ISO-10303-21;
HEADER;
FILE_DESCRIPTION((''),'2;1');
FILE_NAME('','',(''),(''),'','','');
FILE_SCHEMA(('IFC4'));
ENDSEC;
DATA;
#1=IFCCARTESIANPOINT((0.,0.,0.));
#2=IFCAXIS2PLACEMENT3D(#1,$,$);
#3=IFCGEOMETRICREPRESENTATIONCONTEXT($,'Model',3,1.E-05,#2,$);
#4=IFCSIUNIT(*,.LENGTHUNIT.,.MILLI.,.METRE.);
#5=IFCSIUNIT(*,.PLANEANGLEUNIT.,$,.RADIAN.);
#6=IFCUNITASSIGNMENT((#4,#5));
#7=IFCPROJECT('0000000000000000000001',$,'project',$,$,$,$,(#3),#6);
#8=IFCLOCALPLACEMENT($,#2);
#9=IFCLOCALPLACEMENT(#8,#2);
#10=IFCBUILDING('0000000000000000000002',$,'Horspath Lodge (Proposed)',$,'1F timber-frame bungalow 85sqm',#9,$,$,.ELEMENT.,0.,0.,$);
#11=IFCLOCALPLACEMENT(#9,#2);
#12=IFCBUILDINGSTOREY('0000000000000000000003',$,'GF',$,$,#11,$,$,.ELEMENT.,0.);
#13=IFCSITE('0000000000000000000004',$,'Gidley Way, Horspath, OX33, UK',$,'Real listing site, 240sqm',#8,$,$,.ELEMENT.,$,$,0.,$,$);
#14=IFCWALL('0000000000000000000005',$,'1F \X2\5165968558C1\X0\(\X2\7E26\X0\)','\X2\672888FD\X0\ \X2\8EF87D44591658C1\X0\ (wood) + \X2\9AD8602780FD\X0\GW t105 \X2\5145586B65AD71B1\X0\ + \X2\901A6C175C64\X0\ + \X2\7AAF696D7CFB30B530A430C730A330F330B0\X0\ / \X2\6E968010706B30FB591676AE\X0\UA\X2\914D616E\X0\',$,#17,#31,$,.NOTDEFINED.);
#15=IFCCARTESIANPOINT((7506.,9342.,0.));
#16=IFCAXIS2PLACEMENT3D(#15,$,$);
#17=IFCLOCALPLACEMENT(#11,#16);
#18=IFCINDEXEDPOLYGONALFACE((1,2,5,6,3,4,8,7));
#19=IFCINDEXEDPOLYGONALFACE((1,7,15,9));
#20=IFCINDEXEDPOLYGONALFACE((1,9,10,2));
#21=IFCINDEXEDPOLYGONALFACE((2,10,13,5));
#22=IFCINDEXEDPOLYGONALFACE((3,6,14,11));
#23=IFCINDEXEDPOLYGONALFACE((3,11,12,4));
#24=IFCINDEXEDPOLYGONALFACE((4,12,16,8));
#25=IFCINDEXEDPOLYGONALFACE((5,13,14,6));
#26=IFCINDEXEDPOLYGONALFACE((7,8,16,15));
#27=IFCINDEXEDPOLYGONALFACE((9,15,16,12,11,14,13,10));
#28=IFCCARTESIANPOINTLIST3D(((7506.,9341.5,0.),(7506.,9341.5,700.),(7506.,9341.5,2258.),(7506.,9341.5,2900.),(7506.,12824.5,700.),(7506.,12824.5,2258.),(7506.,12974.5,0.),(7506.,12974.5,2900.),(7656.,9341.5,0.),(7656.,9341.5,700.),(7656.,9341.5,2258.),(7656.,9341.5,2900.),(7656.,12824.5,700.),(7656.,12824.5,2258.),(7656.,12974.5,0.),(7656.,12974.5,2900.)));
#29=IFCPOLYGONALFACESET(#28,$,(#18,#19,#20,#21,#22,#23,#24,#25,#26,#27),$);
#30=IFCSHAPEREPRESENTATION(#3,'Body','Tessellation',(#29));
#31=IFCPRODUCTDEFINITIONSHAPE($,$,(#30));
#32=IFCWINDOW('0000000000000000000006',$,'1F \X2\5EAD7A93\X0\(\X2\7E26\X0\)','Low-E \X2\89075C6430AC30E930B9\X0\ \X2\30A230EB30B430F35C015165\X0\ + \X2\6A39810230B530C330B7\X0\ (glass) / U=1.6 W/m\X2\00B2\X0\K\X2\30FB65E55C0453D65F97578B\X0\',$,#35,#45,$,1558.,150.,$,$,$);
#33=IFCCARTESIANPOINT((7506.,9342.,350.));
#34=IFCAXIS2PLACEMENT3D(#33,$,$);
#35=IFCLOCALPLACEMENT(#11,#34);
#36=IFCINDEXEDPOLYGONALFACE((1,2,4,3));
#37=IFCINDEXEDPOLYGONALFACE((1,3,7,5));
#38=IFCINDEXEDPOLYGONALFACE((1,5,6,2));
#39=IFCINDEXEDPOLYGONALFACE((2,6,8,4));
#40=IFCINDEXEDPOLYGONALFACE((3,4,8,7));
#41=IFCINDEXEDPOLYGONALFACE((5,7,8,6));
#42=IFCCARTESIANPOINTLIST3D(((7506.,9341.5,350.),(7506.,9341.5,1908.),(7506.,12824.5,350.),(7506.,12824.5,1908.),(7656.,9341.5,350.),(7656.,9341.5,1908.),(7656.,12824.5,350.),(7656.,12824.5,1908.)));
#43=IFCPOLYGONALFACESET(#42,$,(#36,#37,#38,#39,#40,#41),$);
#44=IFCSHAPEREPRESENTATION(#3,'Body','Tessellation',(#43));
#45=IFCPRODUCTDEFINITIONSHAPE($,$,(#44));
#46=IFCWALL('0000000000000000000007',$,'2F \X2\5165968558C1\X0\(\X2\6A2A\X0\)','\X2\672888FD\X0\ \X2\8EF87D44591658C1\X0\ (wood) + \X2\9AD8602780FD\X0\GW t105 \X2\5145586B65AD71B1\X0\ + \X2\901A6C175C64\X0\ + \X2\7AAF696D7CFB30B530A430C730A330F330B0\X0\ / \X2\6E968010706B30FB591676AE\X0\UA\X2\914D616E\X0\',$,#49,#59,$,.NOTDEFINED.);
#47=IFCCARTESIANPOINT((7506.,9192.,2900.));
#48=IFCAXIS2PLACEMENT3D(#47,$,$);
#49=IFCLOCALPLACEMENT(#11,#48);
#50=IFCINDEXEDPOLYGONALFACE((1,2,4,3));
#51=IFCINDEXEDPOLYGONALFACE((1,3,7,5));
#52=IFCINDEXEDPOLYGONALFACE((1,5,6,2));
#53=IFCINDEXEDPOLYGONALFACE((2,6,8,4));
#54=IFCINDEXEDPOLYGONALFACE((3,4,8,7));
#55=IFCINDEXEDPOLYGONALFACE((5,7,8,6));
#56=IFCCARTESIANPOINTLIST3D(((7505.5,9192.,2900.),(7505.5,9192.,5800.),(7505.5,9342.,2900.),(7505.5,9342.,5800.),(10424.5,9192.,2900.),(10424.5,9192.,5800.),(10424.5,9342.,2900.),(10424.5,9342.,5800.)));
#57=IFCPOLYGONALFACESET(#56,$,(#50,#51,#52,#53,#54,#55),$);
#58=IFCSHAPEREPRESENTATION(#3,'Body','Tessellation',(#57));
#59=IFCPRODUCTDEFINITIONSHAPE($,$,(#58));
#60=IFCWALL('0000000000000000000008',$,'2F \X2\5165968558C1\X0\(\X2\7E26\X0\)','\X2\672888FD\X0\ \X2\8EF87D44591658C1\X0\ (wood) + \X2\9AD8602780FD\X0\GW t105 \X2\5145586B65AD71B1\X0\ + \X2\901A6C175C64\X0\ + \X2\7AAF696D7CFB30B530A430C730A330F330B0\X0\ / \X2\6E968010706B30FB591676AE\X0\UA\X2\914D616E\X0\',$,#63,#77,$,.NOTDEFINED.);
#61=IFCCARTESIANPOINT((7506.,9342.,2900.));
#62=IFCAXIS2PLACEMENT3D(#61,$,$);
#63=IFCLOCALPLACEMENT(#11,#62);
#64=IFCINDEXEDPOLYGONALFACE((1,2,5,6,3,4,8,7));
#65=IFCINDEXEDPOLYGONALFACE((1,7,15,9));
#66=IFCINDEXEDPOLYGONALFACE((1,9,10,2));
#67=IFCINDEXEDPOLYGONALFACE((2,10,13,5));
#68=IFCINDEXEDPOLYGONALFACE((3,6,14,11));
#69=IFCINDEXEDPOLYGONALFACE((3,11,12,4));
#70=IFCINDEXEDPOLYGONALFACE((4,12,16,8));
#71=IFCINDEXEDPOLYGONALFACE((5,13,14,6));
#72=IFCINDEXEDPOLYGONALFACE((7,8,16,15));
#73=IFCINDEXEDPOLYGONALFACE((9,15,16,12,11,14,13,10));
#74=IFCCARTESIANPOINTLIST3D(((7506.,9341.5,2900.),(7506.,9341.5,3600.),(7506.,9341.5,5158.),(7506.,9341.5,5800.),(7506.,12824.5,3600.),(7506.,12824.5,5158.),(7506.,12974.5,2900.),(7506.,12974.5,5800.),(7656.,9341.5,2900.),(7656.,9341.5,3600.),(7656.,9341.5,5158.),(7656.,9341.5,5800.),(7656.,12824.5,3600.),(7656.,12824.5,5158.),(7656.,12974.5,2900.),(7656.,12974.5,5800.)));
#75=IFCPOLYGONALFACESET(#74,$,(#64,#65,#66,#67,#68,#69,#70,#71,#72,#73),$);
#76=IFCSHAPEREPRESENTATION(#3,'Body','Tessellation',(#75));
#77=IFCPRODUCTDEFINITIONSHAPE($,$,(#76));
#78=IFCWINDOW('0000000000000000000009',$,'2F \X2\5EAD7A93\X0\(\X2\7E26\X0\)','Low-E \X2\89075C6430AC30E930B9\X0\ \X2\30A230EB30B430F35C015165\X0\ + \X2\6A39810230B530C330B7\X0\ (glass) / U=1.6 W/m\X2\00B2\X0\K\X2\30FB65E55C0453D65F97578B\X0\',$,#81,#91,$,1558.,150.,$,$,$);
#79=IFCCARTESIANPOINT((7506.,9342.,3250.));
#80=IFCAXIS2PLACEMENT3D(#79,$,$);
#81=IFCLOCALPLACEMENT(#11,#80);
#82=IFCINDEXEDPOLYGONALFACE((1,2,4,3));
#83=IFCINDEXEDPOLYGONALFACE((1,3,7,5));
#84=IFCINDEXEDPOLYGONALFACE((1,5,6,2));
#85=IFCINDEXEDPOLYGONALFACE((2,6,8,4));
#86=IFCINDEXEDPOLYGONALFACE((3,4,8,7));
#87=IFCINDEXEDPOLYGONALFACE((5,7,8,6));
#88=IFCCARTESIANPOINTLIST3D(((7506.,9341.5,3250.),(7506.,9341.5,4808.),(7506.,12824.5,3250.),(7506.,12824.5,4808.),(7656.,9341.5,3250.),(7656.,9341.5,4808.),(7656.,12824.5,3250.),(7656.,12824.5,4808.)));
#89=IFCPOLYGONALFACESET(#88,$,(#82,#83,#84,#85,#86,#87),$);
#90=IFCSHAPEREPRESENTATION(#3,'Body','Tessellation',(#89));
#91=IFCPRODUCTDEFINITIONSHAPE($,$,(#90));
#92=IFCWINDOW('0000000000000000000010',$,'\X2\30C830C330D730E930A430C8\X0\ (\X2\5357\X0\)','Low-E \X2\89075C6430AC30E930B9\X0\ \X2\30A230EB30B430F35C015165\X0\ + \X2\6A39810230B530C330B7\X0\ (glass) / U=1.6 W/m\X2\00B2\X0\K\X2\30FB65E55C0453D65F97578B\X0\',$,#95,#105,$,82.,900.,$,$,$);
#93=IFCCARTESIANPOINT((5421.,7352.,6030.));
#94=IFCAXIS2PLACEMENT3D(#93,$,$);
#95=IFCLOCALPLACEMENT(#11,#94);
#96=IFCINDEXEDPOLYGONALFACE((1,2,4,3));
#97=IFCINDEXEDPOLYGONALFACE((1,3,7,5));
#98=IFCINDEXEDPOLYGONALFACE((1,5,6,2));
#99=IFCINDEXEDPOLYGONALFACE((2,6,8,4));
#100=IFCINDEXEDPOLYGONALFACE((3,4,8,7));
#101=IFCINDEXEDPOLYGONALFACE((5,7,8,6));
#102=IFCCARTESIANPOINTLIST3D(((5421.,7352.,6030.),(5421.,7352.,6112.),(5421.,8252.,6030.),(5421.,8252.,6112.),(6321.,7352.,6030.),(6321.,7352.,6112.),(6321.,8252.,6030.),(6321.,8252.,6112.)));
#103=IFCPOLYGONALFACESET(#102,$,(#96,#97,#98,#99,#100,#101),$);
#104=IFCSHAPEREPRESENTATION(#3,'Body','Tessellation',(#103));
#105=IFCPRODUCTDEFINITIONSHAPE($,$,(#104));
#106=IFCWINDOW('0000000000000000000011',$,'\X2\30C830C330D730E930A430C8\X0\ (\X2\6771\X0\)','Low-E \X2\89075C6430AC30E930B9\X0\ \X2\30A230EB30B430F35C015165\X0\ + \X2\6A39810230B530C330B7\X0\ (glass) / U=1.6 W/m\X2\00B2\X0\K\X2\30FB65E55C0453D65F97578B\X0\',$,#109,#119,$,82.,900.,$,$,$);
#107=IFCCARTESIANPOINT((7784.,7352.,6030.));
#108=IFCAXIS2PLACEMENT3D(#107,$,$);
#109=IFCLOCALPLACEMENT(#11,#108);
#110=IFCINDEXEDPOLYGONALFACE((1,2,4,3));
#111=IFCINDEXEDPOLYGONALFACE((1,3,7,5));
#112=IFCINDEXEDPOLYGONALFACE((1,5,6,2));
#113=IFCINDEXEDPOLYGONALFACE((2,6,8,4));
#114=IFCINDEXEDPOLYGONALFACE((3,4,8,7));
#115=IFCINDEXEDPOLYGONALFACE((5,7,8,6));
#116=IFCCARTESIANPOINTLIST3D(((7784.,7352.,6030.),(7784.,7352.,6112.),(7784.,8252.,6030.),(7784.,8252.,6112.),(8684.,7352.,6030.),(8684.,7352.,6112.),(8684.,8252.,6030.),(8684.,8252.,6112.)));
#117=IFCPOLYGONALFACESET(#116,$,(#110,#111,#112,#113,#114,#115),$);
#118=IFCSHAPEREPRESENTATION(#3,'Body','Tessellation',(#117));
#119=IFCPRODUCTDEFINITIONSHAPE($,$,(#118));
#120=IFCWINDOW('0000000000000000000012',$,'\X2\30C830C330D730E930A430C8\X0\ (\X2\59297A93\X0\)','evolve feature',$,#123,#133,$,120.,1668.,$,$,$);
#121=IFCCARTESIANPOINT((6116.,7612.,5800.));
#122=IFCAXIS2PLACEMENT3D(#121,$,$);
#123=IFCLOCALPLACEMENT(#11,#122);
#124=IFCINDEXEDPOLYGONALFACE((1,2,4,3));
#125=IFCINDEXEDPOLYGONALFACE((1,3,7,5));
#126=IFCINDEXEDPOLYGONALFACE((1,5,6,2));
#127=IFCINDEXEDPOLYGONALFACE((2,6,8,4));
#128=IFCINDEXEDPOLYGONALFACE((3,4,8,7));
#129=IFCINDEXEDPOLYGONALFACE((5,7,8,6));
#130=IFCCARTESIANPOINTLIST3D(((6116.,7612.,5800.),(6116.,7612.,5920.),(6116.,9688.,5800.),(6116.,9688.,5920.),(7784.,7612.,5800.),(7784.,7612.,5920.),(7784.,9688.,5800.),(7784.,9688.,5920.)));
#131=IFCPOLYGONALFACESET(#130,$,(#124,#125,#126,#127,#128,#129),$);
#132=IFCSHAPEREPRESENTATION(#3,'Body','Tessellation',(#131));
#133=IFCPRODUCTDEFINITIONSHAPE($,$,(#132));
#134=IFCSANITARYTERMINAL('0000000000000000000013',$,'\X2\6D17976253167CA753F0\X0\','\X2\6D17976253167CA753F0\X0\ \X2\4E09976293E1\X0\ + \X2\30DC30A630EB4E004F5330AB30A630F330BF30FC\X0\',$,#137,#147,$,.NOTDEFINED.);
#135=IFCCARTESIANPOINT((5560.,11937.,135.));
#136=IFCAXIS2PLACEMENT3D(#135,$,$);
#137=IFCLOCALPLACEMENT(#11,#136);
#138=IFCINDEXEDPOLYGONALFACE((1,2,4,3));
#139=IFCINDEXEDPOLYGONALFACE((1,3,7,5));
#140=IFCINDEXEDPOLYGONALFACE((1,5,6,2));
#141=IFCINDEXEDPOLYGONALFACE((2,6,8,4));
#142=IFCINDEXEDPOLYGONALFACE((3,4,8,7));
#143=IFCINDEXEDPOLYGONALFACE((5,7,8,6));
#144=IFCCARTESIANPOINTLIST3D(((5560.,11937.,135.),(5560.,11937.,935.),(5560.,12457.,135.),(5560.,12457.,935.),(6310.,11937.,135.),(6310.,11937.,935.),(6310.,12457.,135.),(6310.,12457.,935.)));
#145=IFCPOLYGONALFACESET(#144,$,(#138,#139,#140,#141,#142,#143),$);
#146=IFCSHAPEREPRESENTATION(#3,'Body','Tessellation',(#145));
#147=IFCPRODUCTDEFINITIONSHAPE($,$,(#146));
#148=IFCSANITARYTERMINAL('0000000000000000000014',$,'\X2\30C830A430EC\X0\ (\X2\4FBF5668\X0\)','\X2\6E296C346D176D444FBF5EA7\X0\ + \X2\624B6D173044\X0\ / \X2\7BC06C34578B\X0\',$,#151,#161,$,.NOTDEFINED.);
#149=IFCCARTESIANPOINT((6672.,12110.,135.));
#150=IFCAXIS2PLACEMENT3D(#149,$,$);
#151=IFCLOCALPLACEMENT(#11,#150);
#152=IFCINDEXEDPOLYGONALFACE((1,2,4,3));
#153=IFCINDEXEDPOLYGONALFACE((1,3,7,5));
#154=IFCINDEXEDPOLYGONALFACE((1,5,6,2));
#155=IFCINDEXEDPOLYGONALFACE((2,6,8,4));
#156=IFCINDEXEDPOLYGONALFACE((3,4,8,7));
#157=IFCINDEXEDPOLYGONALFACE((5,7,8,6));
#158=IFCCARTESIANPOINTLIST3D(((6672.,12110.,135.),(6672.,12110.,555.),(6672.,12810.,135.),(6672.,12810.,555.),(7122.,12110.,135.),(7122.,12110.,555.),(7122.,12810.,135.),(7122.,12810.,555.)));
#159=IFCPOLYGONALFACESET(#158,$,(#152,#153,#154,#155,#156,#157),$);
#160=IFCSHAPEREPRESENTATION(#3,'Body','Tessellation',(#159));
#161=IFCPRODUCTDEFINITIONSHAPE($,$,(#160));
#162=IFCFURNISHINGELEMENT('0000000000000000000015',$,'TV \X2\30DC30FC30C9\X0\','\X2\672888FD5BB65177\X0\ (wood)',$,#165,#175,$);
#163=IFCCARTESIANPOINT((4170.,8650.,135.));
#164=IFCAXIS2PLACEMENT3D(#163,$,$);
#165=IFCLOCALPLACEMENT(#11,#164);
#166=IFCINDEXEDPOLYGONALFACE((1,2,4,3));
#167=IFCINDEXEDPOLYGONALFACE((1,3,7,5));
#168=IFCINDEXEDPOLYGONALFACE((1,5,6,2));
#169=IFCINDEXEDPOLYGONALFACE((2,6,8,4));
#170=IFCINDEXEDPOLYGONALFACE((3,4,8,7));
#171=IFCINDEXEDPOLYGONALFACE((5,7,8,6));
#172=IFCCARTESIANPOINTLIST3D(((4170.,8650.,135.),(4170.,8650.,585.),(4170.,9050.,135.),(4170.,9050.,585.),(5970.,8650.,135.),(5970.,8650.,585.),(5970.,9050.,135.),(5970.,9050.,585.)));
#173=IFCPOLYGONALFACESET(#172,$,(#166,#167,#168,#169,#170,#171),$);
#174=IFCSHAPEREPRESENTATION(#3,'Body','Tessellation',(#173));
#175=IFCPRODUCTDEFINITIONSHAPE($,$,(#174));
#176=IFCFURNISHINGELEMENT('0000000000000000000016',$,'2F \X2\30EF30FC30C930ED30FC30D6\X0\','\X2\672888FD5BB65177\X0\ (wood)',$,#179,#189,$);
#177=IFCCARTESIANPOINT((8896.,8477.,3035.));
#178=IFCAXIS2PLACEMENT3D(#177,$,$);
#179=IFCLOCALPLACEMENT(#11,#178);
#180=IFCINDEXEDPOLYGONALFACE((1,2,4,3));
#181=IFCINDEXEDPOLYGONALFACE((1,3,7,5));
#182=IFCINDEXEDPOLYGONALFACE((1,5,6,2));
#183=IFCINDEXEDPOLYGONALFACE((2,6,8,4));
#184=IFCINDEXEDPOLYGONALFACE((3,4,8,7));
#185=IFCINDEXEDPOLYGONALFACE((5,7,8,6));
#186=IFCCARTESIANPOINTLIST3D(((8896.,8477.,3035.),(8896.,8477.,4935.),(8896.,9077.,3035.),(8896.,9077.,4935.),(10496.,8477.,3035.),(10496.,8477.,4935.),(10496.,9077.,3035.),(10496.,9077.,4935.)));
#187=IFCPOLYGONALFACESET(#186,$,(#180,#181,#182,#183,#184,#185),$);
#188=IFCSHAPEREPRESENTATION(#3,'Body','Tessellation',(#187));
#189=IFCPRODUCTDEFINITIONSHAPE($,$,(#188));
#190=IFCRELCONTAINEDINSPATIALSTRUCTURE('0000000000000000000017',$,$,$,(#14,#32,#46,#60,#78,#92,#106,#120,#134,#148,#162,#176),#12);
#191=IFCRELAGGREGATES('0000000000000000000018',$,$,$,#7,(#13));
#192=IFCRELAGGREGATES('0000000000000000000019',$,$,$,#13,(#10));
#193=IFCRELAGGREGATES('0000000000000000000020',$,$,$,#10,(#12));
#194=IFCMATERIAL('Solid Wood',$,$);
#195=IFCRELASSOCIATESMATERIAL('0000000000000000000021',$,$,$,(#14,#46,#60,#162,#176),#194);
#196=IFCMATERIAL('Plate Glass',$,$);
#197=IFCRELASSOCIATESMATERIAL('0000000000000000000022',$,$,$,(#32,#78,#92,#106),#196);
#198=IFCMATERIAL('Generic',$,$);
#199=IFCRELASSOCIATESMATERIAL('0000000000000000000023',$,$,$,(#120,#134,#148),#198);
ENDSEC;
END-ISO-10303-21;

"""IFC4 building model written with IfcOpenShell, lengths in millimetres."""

from ifc_helpers import new_model, si_unit, frame, frame_2d, origin, place, context, project, spatial, rectangle, extrude, material, element, fill, save


model = new_model("IFC4")

# Units and contexts
model_context = context("Model", 3, precision=1e-05, world=origin())
ifc_project = project(units=[si_unit("LENGTHUNIT", "METRE", prefix="MILLI"), si_unit("PLANEANGLEUNIT", "RADIAN")], contexts=[model_context])

# Site, building, storey
site_placement = place(None, origin())
site = spatial("IfcSite", under=ifc_project, at=site_placement, Name="Gidley Way, Horspath, OX33, UK", ObjectType="Real listing site, 240sqm", CompositionType="ELEMENT", RefElevation=0.0)
building_placement = place(site_placement, origin())
building = spatial("IfcBuilding", under=site, at=building_placement, Name="Horspath Lodge (Proposed)", ObjectType="1F timber-frame bungalow 85sqm", CompositionType="ELEMENT", ElevationOfRefHeight=0.0, ElevationOfTerrain=0.0)
storey_placement = place(building_placement, origin())
storey = spatial("IfcBuildingStorey", under=building, at=storey_placement, Name="GF", CompositionType="ELEMENT", Elevation=0.0)

# Shared definitions
ifc_material_1 = material(Name="Solid Wood")

# Wall, opening, window
wall_1_placement = place(storey_placement, frame((7506.0, 9342.0, 0.0)))
wall_1 = element("IfcWall", 1, at=wall_1_placement, inside=storey, material=ifc_material_1, Name="1F 入隅壁(縦)", Description="木製 軸組外壁 (wood) + 高性能GW t105 充填断熱 + 通気層 + 窯業系サイディング / 準耐火・外皮UA配慮", PredefinedType="NOTDEFINED", context=model_context, shape_type="SweptSolid", body=[
    extrude(rectangle(XDim=150.0, YDim=3633.0, at=frame_2d((75.0, 1816.0))), frame((7506.0, 9342.0, 0.0)), (0.0, 0.0, 1.0), 2900.0),
])
opening_1_placement = place(storey_placement, frame((7506.0, 9342.0, 350.0)))
opening_1 = element("IfcOpeningElement", 2, at=opening_1_placement, cuts=wall_1, PredefinedType="NOTDEFINED", context=model_context, shape_type="SweptSolid", body=[
    extrude(rectangle(XDim=150.0, YDim=3483.0, at=frame_2d((75.0, 1741.0))), frame((7506.0, 9342.0, 350.0)), (0.0, 0.0, 1.0), 1558.0),
])
ifc_material_2 = material(Name="Plate Glass")
window_1_placement = place(storey_placement, frame((7506.0, 9342.0, 350.0)))
window_1 = element("IfcWindow", 3, at=window_1_placement, inside=storey, material=ifc_material_2, Name="1F 庭窓(縦)", Description="Low-E 複層ガラス アルゴン封入 + 樹脂サッシ (glass) / U=1.6 W/m²K・日射取得型", OverallHeight=1558.0, OverallWidth=150.0, context=model_context, shape_type="SweptSolid", body=[
    extrude(rectangle(XDim=150.0, YDim=3483.0, at=frame_2d((75.0, 1741.0))), frame((7506.0, 9342.0, 350.0)), (0.0, 0.0, 1.0), 1558.0),
])
fill(opening_1, window_1)

# Wall
wall_2_placement = place(storey_placement, frame((7506.0, 9192.0, 2900.0)))
element("IfcWall", 4, at=wall_2_placement, inside=storey, material=ifc_material_1, Name="2F 入隅壁(横)", Description="木製 軸組外壁 (wood) + 高性能GW t105 充填断熱 + 通気層 + 窯業系サイディング / 準耐火・外皮UA配慮", PredefinedType="NOTDEFINED", context=model_context, shape_type="SweptSolid", body=[
    extrude(rectangle(XDim=2919.0, YDim=150.0, at=frame_2d((1459.0, 75.0))), frame((7506.0, 9192.0, 2900.0)), (0.0, 0.0, 1.0), 2900.0),
])

# Wall, opening, window
wall_3_placement = place(storey_placement, frame((7506.0, 9342.0, 2900.0)))
wall_3 = element("IfcWall", 5, at=wall_3_placement, inside=storey, material=ifc_material_1, Name="2F 入隅壁(縦)", Description="木製 軸組外壁 (wood) + 高性能GW t105 充填断熱 + 通気層 + 窯業系サイディング / 準耐火・外皮UA配慮", PredefinedType="NOTDEFINED", context=model_context, shape_type="SweptSolid", body=[
    extrude(rectangle(XDim=150.0, YDim=3633.0, at=frame_2d((75.0, 1816.0))), frame((7506.0, 9342.0, 2900.0)), (0.0, 0.0, 1.0), 2900.0),
])
opening_2_placement = place(storey_placement, frame((7506.0, 9342.0, 3250.0)))
opening_2 = element("IfcOpeningElement", 6, at=opening_2_placement, cuts=wall_3, PredefinedType="NOTDEFINED", context=model_context, shape_type="SweptSolid", body=[
    extrude(rectangle(XDim=150.0, YDim=3483.0, at=frame_2d((75.0, 1741.0))), frame((7506.0, 9342.0, 3250.0)), (0.0, 0.0, 1.0), 1558.0),
])
window_2_placement = place(storey_placement, frame((7506.0, 9342.0, 3250.0)))
window_2 = element("IfcWindow", 7, at=window_2_placement, inside=storey, material=ifc_material_2, Name="2F 庭窓(縦)", Description="Low-E 複層ガラス アルゴン封入 + 樹脂サッシ (glass) / U=1.6 W/m²K・日射取得型", OverallHeight=1558.0, OverallWidth=150.0, context=model_context, shape_type="SweptSolid", body=[
    extrude(rectangle(XDim=150.0, YDim=3483.0, at=frame_2d((75.0, 1741.0))), frame((7506.0, 9342.0, 3250.0)), (0.0, 0.0, 1.0), 1558.0),
])
fill(opening_2, window_2)

# Windows
window_3_placement = place(storey_placement, frame((5421.0, 7352.0, 6030.0)))
element("IfcWindow", 8, at=window_3_placement, inside=storey, material=ifc_material_2, Name="トップライト (南)", Description="Low-E 複層ガラス アルゴン封入 + 樹脂サッシ (glass) / U=1.6 W/m²K・日射取得型", OverallHeight=82.0, OverallWidth=900.0, context=model_context, shape_type="SweptSolid", body=[
    extrude(rectangle(XDim=900.0, YDim=900.0, at=frame_2d((450.0, 450.0))), frame((5421.0, 7352.0, 6030.0)), (0.0, 0.0, 1.0), 82.0),
])
window_4_placement = place(storey_placement, frame((7784.0, 7352.0, 6030.0)))
element("IfcWindow", 9, at=window_4_placement, inside=storey, material=ifc_material_2, Name="トップライト (東)", Description="Low-E 複層ガラス アルゴン封入 + 樹脂サッシ (glass) / U=1.6 W/m²K・日射取得型", OverallHeight=82.0, OverallWidth=900.0, context=model_context, shape_type="SweptSolid", body=[
    extrude(rectangle(XDim=900.0, YDim=900.0, at=frame_2d((450.0, 450.0))), frame((7784.0, 7352.0, 6030.0)), (0.0, 0.0, 1.0), 82.0),
])
ifc_material_3 = material(Name="Generic")
window_5_placement = place(storey_placement, frame((6116.0, 7612.0, 5800.0)))
element("IfcWindow", 10, at=window_5_placement, inside=storey, material=ifc_material_3, Name="トップライト (天窓)", Description="evolve feature", OverallHeight=120.0, OverallWidth=1668.0, context=model_context, shape_type="SweptSolid", body=[
    extrude(rectangle(XDim=1668.0, YDim=2076.0, at=frame_2d((834.0, 1038.0))), frame((6116.0, 7612.0, 5800.0)), (0.0, 0.0, 1.0), 120.0),
])

# Sanitary terminals
sanitary_terminal_1_placement = place(storey_placement, frame((5560.0, 11937.0, 135.0)))
element("IfcSanitaryTerminal", 11, at=sanitary_terminal_1_placement, inside=storey, material=ifc_material_3, Name="洗面化粧台", Description="洗面化粧台 三面鏡 + ボウル一体カウンター", PredefinedType="NOTDEFINED", context=model_context, shape_type="SweptSolid", body=[
    extrude(rectangle(XDim=750.0, YDim=520.0, at=frame_2d((375.0, 260.0))), frame((5560.0, 11937.0, 135.0)), (0.0, 0.0, 1.0), 800.0),
])
sanitary_terminal_2_placement = place(storey_placement, frame((6672.0, 12110.0, 135.0)))
element("IfcSanitaryTerminal", 12, at=sanitary_terminal_2_placement, inside=storey, material=ifc_material_3, Name="トイレ (便器)", Description="温水洗浄便座 + 手洗い / 節水型", PredefinedType="NOTDEFINED", context=model_context, shape_type="SweptSolid", body=[
    extrude(rectangle(XDim=450.0, YDim=700.0, at=frame_2d((225.0, 350.0))), frame((6672.0, 12110.0, 135.0)), (0.0, 0.0, 1.0), 420.0),
])

# Furnishing elements
furnishing_1_placement = place(storey_placement, frame((4170.0, 8650.0, 135.0)))
element("IfcFurnishingElement", 13, at=furnishing_1_placement, inside=storey, material=ifc_material_1, Name="TV ボード", Description="木製家具 (wood)", context=model_context, shape_type="SweptSolid", body=[
    extrude(rectangle(XDim=1800.0, YDim=400.0, at=frame_2d((900.0, 200.0))), frame((4170.0, 8650.0, 135.0)), (0.0, 0.0, 1.0), 450.0),
])
furnishing_2_placement = place(storey_placement, frame((8896.0, 8477.0, 3035.0)))
element("IfcFurnishingElement", 14, at=furnishing_2_placement, inside=storey, material=ifc_material_1, Name="2F ワードローブ", Description="木製家具 (wood)", context=model_context, shape_type="SweptSolid", body=[
    extrude(rectangle(XDim=1600.0, YDim=600.0, at=frame_2d((800.0, 300.0))), frame((8896.0, 8477.0, 3035.0)), (0.0, 0.0, 1.0), 1900.0),
])

save(model, "model.ifc")
